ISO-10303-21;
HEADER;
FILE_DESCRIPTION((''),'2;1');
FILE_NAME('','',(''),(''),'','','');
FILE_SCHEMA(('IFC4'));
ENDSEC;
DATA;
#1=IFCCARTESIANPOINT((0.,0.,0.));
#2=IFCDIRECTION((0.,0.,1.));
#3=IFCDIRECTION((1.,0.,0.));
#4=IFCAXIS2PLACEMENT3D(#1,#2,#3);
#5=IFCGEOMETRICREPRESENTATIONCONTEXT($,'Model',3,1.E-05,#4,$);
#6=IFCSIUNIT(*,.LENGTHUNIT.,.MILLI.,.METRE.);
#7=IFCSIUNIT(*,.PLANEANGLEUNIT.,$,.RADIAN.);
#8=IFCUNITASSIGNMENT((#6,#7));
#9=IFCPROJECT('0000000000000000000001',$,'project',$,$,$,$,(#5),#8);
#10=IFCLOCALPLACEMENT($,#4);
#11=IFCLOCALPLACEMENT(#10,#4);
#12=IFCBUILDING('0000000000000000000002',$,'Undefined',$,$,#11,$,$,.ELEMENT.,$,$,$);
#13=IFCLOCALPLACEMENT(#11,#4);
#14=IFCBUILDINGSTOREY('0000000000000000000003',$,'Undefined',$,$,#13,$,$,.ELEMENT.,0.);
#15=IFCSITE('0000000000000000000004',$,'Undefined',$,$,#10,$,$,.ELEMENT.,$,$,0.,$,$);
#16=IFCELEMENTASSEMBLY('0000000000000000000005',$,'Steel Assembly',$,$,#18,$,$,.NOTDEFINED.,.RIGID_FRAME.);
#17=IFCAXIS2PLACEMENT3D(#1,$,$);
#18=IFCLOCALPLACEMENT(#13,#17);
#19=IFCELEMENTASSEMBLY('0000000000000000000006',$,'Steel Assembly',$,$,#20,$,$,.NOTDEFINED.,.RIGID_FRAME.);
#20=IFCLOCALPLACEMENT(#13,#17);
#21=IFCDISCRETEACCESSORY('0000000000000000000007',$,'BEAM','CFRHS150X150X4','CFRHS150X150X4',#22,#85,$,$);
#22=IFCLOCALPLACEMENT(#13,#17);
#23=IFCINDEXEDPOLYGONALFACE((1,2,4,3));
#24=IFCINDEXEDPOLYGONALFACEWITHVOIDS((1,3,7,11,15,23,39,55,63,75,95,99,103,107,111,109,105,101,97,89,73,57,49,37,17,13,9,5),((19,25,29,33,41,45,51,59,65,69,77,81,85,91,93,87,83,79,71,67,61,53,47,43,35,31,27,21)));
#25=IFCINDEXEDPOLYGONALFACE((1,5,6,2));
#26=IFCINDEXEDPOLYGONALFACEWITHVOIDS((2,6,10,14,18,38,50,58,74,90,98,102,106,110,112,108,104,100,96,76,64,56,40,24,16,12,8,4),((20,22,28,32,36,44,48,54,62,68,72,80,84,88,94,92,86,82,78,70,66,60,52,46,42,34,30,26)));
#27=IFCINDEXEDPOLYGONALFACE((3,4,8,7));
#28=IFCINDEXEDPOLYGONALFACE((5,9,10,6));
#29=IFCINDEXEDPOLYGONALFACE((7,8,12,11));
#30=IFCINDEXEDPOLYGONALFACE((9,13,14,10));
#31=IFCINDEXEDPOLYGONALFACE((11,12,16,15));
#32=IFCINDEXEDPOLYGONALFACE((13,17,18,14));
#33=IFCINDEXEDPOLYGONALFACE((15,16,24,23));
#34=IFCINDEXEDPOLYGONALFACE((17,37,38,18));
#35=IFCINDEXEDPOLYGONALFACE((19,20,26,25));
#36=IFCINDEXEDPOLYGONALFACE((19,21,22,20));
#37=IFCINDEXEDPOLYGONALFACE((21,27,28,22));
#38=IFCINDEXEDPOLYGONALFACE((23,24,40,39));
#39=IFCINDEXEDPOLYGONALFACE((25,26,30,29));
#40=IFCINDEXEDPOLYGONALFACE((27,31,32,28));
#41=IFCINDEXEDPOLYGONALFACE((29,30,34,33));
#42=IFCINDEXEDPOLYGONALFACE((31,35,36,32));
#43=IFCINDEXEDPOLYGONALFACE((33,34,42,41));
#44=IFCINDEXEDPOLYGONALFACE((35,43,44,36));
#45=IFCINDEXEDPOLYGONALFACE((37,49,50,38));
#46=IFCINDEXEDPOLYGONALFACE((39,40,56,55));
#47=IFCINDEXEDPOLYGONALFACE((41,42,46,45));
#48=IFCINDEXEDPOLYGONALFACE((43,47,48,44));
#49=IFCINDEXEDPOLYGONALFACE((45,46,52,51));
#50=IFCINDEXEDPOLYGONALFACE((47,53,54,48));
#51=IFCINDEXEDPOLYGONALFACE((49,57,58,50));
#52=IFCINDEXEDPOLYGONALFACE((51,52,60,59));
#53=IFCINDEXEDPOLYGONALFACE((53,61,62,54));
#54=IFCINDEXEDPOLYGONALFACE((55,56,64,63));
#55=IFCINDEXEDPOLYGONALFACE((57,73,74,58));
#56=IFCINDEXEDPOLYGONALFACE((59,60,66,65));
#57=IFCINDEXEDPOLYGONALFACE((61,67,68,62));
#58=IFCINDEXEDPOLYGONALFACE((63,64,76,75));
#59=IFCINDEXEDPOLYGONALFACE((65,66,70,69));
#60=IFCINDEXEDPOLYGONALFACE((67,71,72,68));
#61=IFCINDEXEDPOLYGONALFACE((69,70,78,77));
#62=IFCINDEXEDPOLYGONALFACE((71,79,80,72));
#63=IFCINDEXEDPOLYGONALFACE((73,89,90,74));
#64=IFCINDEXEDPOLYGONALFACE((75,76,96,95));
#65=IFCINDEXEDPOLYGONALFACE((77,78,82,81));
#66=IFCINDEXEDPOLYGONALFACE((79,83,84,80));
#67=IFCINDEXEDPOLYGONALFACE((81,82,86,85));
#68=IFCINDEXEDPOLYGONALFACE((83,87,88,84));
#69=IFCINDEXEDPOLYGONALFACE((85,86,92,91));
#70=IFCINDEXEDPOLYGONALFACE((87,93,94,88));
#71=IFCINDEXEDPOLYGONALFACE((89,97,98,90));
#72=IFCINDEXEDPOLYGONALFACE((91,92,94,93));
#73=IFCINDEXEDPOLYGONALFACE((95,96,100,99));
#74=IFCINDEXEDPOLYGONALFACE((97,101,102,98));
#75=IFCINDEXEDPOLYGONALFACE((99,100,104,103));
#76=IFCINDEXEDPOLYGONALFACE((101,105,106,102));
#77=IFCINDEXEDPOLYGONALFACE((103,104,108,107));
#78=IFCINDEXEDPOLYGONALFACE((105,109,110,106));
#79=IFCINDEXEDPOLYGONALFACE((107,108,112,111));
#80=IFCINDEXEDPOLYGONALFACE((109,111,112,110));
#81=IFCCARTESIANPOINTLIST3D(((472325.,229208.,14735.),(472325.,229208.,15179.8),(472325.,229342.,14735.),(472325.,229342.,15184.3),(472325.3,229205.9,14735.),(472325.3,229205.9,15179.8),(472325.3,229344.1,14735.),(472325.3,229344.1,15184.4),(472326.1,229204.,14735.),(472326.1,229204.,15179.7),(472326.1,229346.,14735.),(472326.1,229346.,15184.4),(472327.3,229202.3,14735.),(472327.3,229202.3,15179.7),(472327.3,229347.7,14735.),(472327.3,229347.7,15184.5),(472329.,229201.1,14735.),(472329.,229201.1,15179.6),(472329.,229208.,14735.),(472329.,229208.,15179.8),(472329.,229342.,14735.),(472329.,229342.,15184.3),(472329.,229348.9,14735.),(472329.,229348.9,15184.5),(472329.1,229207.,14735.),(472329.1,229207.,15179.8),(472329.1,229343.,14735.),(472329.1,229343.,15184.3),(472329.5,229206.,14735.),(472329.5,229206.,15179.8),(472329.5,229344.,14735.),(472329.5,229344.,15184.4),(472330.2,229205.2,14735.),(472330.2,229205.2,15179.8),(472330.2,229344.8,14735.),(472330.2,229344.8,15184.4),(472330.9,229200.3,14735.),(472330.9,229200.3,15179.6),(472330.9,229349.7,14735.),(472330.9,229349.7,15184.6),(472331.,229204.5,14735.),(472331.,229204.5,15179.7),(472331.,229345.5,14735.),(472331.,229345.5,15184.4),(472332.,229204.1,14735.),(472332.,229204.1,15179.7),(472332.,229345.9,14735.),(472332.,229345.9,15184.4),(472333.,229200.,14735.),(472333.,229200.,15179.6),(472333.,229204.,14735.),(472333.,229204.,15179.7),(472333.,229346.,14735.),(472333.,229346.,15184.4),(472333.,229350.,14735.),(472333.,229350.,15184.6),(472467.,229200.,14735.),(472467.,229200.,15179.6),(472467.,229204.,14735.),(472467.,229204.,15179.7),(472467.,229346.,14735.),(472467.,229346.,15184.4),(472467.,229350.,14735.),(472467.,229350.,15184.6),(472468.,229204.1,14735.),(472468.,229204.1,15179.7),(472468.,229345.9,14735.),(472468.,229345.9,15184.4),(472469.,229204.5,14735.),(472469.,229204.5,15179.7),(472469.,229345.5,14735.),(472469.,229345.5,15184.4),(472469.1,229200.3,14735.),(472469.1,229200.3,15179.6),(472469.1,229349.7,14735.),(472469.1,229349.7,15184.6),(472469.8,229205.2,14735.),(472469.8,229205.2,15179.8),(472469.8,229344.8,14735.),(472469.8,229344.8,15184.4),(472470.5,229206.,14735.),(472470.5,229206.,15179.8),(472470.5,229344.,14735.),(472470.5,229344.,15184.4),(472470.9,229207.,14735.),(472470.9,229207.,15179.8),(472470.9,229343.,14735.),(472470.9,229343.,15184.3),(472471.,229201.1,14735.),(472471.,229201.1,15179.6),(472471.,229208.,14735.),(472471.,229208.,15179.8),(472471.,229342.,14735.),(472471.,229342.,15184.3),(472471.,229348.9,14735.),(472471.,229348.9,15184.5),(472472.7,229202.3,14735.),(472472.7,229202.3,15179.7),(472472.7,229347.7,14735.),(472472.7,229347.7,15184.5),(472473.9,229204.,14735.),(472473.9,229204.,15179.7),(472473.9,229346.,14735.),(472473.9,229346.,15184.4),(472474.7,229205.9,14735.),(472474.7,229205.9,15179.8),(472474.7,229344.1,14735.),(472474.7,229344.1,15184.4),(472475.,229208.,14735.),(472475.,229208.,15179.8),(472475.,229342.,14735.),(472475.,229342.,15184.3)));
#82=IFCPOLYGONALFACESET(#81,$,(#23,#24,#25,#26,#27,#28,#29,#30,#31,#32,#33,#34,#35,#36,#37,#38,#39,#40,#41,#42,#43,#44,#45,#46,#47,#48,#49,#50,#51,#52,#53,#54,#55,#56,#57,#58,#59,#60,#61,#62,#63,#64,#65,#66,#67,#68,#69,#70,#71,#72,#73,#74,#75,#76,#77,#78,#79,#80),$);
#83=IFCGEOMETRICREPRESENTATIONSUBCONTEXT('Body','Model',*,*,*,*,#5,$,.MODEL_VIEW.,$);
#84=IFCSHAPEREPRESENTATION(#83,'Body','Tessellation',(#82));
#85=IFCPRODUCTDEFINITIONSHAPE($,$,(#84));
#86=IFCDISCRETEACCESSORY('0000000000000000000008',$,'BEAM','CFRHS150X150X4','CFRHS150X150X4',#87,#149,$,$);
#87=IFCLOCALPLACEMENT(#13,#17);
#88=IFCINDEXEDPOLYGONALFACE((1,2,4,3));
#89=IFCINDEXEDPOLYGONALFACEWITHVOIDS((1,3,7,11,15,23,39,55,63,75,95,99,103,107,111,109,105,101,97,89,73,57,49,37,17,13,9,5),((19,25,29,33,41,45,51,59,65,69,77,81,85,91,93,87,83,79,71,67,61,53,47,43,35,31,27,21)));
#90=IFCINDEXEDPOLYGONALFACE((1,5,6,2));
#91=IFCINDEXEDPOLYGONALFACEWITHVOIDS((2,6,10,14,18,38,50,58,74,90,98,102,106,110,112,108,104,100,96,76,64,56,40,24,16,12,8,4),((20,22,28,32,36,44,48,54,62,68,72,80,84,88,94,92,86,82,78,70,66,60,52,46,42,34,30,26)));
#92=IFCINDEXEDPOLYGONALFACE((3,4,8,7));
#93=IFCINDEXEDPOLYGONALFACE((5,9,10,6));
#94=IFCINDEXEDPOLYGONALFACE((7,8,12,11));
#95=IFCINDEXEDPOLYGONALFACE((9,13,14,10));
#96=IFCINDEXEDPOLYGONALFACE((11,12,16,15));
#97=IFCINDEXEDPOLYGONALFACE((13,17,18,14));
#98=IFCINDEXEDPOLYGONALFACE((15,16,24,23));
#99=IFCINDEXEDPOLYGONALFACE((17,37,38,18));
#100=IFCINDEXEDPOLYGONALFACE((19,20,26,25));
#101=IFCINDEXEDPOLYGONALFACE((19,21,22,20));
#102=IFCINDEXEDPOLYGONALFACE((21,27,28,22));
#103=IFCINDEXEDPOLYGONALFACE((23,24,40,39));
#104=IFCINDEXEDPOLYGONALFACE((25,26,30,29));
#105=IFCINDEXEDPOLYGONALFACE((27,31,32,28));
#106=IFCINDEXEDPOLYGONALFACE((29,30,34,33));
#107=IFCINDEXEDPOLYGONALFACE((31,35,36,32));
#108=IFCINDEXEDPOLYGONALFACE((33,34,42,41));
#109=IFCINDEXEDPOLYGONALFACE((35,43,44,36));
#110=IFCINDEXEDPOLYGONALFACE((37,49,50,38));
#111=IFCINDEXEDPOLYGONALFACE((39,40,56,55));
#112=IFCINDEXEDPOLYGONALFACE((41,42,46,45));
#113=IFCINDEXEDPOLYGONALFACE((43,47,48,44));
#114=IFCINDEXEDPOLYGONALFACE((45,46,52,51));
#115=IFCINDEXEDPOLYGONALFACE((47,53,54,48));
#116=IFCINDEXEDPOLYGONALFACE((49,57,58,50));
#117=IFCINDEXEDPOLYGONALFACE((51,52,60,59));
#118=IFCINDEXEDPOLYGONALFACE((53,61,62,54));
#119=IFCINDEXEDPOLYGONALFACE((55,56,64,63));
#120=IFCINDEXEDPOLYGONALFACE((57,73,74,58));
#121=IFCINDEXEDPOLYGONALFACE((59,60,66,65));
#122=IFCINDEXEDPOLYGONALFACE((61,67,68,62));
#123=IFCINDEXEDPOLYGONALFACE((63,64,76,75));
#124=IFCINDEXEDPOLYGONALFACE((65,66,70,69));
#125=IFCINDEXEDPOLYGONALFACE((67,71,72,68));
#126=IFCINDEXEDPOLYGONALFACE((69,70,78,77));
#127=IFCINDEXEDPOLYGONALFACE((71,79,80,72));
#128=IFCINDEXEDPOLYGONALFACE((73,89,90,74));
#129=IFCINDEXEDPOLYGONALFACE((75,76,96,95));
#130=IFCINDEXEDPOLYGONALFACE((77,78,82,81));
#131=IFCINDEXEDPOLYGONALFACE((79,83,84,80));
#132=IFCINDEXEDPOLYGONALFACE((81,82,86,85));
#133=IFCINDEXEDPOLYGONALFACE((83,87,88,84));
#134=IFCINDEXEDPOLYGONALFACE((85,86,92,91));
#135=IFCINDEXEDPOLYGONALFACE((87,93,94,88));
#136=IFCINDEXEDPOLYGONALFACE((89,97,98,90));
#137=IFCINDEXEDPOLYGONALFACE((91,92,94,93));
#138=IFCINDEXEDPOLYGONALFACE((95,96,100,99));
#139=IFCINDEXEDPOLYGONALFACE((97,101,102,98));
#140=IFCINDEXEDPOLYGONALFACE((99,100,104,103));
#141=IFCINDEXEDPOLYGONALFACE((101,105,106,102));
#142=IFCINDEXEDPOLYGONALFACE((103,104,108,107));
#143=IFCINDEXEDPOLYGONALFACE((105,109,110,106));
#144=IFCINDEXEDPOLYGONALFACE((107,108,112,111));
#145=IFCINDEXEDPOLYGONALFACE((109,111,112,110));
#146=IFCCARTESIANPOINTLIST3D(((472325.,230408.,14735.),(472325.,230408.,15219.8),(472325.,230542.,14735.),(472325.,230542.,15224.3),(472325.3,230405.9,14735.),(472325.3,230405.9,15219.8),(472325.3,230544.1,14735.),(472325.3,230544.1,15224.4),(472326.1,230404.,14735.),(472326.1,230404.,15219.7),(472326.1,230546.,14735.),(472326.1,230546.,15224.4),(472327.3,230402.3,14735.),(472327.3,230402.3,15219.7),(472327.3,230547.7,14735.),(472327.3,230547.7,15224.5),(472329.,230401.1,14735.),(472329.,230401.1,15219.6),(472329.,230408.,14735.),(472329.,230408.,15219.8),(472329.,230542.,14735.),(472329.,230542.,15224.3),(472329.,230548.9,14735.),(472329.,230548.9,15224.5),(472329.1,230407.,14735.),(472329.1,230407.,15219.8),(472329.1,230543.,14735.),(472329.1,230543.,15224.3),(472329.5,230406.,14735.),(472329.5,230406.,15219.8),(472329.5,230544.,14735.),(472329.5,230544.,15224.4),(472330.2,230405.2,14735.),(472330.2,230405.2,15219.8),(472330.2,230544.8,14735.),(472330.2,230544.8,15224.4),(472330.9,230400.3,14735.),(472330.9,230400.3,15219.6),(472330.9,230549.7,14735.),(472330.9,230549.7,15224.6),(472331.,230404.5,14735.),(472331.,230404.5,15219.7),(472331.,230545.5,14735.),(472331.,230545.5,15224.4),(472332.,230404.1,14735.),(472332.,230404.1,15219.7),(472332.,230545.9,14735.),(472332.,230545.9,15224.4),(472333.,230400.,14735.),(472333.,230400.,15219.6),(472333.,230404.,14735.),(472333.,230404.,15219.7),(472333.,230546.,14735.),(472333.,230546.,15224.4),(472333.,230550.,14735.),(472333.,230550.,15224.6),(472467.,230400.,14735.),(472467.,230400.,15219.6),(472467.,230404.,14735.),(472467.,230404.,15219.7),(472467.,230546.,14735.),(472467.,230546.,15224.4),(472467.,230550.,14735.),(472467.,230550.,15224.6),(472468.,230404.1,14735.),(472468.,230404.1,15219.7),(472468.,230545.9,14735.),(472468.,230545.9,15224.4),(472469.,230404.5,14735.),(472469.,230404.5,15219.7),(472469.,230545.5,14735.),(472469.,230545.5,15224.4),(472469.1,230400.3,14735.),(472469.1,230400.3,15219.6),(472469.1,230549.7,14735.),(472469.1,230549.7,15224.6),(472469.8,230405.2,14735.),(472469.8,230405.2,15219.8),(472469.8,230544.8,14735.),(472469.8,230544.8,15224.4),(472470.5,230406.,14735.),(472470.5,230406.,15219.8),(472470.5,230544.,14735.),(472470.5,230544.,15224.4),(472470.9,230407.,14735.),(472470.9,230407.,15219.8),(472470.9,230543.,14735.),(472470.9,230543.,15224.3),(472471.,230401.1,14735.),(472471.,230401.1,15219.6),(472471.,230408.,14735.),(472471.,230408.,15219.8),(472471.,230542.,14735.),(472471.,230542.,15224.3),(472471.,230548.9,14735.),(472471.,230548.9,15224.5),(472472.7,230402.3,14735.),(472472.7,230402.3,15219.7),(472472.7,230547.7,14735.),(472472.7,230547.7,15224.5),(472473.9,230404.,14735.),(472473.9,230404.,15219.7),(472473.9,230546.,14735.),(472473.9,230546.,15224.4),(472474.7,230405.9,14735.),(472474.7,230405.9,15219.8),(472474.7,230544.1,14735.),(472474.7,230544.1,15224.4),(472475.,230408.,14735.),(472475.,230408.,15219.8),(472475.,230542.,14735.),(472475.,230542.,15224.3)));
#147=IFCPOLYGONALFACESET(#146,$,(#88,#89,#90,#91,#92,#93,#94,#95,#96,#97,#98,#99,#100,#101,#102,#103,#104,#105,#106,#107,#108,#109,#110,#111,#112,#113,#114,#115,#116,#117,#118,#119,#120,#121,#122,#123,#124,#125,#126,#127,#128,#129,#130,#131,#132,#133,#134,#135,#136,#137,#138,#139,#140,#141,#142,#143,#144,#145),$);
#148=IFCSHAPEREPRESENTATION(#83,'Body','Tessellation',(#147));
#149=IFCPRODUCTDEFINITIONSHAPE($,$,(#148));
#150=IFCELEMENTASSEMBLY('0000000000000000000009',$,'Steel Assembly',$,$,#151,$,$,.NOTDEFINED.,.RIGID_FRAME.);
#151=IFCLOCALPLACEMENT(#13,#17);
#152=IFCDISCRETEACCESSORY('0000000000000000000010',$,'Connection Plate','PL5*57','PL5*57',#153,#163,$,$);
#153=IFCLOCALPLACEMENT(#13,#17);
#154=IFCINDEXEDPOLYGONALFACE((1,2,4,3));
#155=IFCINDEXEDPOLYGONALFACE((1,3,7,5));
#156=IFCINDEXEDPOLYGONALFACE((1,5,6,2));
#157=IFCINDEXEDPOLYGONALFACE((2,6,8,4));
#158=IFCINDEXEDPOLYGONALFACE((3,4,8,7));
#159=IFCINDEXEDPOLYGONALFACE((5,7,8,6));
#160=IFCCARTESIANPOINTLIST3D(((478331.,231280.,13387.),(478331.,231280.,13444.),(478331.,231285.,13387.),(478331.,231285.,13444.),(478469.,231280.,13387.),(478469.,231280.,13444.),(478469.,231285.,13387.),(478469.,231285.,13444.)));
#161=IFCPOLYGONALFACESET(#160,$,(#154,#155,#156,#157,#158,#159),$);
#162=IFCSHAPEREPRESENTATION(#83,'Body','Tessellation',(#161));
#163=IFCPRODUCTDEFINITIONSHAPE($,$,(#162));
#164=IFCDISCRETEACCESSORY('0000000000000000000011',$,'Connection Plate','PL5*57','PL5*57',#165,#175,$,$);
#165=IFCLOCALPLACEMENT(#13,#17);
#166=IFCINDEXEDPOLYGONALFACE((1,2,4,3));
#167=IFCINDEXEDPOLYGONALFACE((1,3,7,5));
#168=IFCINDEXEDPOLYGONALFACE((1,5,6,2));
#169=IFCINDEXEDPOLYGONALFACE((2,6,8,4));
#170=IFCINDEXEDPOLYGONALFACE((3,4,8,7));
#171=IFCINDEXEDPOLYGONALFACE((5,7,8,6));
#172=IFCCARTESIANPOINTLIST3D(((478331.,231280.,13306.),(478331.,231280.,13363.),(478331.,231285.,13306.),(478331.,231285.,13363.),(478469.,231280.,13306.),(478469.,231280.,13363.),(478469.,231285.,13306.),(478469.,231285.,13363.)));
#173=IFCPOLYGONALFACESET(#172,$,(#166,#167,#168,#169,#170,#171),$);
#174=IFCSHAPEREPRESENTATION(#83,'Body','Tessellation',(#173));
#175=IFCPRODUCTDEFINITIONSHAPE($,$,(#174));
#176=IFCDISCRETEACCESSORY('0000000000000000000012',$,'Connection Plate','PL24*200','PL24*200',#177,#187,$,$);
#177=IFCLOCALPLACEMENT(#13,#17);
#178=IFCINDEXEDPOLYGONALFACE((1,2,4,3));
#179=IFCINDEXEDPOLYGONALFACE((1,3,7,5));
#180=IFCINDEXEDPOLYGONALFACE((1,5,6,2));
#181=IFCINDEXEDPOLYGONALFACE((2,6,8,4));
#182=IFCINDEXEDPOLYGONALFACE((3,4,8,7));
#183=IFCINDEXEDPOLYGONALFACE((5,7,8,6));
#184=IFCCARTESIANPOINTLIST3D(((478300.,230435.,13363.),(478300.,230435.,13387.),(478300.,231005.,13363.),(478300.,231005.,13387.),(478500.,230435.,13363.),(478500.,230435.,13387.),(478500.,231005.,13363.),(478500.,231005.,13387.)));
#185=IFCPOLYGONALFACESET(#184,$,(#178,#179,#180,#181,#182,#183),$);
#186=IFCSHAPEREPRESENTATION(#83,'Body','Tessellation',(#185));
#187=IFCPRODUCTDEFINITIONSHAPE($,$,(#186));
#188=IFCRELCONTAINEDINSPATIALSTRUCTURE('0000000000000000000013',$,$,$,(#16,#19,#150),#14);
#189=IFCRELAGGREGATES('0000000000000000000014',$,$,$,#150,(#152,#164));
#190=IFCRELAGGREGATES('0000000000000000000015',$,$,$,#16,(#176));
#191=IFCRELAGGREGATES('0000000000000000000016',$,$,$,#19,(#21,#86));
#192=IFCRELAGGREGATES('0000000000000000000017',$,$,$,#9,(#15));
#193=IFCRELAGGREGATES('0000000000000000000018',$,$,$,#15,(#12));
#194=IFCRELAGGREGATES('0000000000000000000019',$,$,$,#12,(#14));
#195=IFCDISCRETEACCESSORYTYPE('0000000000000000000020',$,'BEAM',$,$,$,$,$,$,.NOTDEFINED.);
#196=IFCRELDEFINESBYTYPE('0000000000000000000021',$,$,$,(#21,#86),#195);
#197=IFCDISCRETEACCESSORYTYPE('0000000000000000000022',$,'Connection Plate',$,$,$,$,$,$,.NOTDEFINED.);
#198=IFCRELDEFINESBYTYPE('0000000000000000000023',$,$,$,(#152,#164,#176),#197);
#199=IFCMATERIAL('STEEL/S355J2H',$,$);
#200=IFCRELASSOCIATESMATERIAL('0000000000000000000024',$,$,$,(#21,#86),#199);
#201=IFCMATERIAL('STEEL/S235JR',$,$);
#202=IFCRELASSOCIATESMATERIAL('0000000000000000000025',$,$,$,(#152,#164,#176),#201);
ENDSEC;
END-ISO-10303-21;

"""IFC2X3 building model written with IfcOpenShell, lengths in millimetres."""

from ifc_helpers import new_model, si_unit, frame, origin_with_axes, origin_2d_with_axis, place, context, subcontext, project, spatial, polyline, hollow_rectangle, outline, extrude, clip, halfspace, material, type_object, element, aggregate, save


model = new_model("IFC2X3")

# Units and contexts
model_context = context("Model", 3, precision=1e-05, world=origin_with_axes())
body_context = subcontext(model_context, "Body", "Model", "MODEL_VIEW")
ifc_project = project(units=[si_unit("LENGTHUNIT", "METRE", prefix="MILLI"), si_unit("PLANEANGLEUNIT", "RADIAN")], contexts=[model_context])

# Site, building, storey
site_placement = place(None, origin_with_axes())
site = spatial("IfcSite", under=ifc_project, at=site_placement, Name="Undefined", CompositionType="ELEMENT", RefElevation=0.0)
building_placement = place(site_placement, origin_with_axes())
building = spatial("IfcBuilding", under=site, at=building_placement, Name="Undefined", CompositionType="ELEMENT")
storey_placement = place(building_placement, origin_with_axes())
storey = spatial("IfcBuildingStorey", under=building, at=storey_placement, Name="Undefined", CompositionType="ELEMENT", Elevation=0.0)

# Shared definitions
ifc_material_1 = material(Name="STEEL/S235JR")

# Element assemblies, discrete accessories
assembly_1_placement = place(storey_placement, origin_with_axes())
assembly_1 = element("IfcElementAssembly", 1, at=assembly_1_placement, inside=storey, Name="Steel Assembly", AssemblyPlace="NOTDEFINED", PredefinedType="RIGID_FRAME")
ifc_material_2 = material(Name="STEEL/S355J2H")
assembly_2_placement = place(storey_placement, origin_with_axes())
assembly_2 = element("IfcElementAssembly", 2, at=assembly_2_placement, inside=storey, Name="Steel Assembly", AssemblyPlace="NOTDEFINED", PredefinedType="RIGID_FRAME")
discrete_accessory_type_1 = type_object("IfcDiscreteAccessoryType", Name="BEAM")
discrete_accessory_1_placement = place(assembly_2_placement, frame((472400.0, 229275.0, 14720.0), z_axis=(0.0, 0.0, 1.0), x_axis=(1.0, 0.0, 0.0)))
discrete_accessory_1 = element("IfcDiscreteAccessory", 3, at=discrete_accessory_1_placement, type_object=discrete_accessory_type_1, material=ifc_material_2, Name="BEAM", Description="CFRHS150X150X4", ObjectType="CFRHS150X150X4", context=body_context, shape_type="Clipping", body=[
    clip(extrude(hollow_rectangle(XDim=150.0, YDim=150.0, WallThickness=4.0, InnerFilletRadius=4.0, OuterFilletRadius=8.0, at=origin_2d_with_axis()), frame((0.0, 0.0, 464.6), z_axis=(0.0, 0.0, -1.0), x_axis=(0.0, -1.0, 0.0)), (0.0, 0.0, 1.0), 449.6), halfspace(frame((-1000.0, 2.7, 462.2), z_axis=(0.0, 0.033315, -0.999445), x_axis=(0.0, -0.999445, -0.033315)), True)),
])
discrete_accessory_2_placement = place(assembly_2_placement, frame((472400.0, 230475.0, 14720.0), z_axis=(0.0, 0.0, 1.0), x_axis=(1.0, 0.0, 0.0)))
discrete_accessory_2 = element("IfcDiscreteAccessory", 4, at=discrete_accessory_2_placement, type_object=discrete_accessory_type_1, material=ifc_material_2, Name="BEAM", Description="CFRHS150X150X4", ObjectType="CFRHS150X150X4", context=body_context, shape_type="Clipping", body=[
    clip(extrude(hollow_rectangle(XDim=150.0, YDim=150.0, WallThickness=4.0, InnerFilletRadius=4.0, OuterFilletRadius=8.0, at=origin_2d_with_axis()), frame((0.0, 0.0, 504.6), z_axis=(0.0, 0.0, -1.0), x_axis=(0.0, -1.0, 0.0)), (0.0, 0.0, 1.0), 489.6), halfspace(frame((-1000.0, 2.7, 502.2), z_axis=(0.0, 0.033315, -0.999445), x_axis=(0.0, -0.999445, -0.033315)), True)),
])
assembly_3_placement = place(storey_placement, origin_with_axes())
assembly_3 = element("IfcElementAssembly", 5, at=assembly_3_placement, inside=storey, Name="Steel Assembly", AssemblyPlace="NOTDEFINED", PredefinedType="RIGID_FRAME")
discrete_accessory_type_2 = type_object("IfcDiscreteAccessoryType", Name="Connection Plate")
discrete_accessory_3_placement = place(assembly_3_placement, frame((478469.0, 231282.5, 13444.0), z_axis=(0.0, -1.0, 0.0), x_axis=(-1.0, 0.0, 0.0)))
discrete_accessory_3 = element("IfcDiscreteAccessory", 6, at=discrete_accessory_3_placement, type_object=discrete_accessory_type_2, material=ifc_material_1, Name="Connection Plate", Description="PL5*57", ObjectType="PL5*57", context=body_context, shape_type="SweptSolid", body=[
    extrude(outline(polyline([(0.0, 0.0), (138.0, 0.0), (138.0, 57.0), (0.0, 57.0), (0.0, 0.0)])), frame((0.0, 0.0, -2.5), z_axis=(0.0, 0.0, 1.0), x_axis=(1.0, 0.0, 0.0)), (0.0, 0.0, 1.0), 5.0),
])
discrete_accessory_4_placement = place(assembly_3_placement, frame((478469.0, 231282.5, 13363.0), z_axis=(0.0, -1.0, 0.0), x_axis=(-1.0, 0.0, 0.0)))
discrete_accessory_4 = element("IfcDiscreteAccessory", 7, at=discrete_accessory_4_placement, type_object=discrete_accessory_type_2, material=ifc_material_1, Name="Connection Plate", Description="PL5*57", ObjectType="PL5*57", context=body_context, shape_type="SweptSolid", body=[
    extrude(outline(polyline([(0.0, 0.0), (138.0, 0.0), (138.0, 57.0), (0.0, 57.0), (0.0, 0.0)])), frame((0.0, 0.0, -2.5), z_axis=(0.0, 0.0, 1.0), x_axis=(1.0, 0.0, 0.0)), (0.0, 0.0, 1.0), 5.0),
])
aggregate(assembly_3, [discrete_accessory_3, discrete_accessory_4])

# Discrete accessory
discrete_accessory_5_placement = place(assembly_1_placement, frame((478500.0, 230435.0, 13375.0), z_axis=(0.0, 0.0, 1.0), x_axis=(0.0, 1.0, 0.0)))
discrete_accessory_5 = element("IfcDiscreteAccessory", 8, at=discrete_accessory_5_placement, type_object=discrete_accessory_type_2, material=ifc_material_1, Name="Connection Plate", Description="PL24*200", ObjectType="PL24*200", context=body_context, shape_type="SweptSolid", body=[
    extrude(outline(polyline([(0.0, 0.0), (570.0, 0.0), (570.0, 200.0), (0.0, 200.0), (0.0, 0.0)])), frame((0.0, 0.0, -12.0), z_axis=(0.0, 0.0, 1.0), x_axis=(1.0, 0.0, 0.0)), (0.0, 0.0, 1.0), 24.0),
])
aggregate(assembly_1, [discrete_accessory_5])
aggregate(assembly_2, [discrete_accessory_1, discrete_accessory_2])

save(model, "model.ifc")
